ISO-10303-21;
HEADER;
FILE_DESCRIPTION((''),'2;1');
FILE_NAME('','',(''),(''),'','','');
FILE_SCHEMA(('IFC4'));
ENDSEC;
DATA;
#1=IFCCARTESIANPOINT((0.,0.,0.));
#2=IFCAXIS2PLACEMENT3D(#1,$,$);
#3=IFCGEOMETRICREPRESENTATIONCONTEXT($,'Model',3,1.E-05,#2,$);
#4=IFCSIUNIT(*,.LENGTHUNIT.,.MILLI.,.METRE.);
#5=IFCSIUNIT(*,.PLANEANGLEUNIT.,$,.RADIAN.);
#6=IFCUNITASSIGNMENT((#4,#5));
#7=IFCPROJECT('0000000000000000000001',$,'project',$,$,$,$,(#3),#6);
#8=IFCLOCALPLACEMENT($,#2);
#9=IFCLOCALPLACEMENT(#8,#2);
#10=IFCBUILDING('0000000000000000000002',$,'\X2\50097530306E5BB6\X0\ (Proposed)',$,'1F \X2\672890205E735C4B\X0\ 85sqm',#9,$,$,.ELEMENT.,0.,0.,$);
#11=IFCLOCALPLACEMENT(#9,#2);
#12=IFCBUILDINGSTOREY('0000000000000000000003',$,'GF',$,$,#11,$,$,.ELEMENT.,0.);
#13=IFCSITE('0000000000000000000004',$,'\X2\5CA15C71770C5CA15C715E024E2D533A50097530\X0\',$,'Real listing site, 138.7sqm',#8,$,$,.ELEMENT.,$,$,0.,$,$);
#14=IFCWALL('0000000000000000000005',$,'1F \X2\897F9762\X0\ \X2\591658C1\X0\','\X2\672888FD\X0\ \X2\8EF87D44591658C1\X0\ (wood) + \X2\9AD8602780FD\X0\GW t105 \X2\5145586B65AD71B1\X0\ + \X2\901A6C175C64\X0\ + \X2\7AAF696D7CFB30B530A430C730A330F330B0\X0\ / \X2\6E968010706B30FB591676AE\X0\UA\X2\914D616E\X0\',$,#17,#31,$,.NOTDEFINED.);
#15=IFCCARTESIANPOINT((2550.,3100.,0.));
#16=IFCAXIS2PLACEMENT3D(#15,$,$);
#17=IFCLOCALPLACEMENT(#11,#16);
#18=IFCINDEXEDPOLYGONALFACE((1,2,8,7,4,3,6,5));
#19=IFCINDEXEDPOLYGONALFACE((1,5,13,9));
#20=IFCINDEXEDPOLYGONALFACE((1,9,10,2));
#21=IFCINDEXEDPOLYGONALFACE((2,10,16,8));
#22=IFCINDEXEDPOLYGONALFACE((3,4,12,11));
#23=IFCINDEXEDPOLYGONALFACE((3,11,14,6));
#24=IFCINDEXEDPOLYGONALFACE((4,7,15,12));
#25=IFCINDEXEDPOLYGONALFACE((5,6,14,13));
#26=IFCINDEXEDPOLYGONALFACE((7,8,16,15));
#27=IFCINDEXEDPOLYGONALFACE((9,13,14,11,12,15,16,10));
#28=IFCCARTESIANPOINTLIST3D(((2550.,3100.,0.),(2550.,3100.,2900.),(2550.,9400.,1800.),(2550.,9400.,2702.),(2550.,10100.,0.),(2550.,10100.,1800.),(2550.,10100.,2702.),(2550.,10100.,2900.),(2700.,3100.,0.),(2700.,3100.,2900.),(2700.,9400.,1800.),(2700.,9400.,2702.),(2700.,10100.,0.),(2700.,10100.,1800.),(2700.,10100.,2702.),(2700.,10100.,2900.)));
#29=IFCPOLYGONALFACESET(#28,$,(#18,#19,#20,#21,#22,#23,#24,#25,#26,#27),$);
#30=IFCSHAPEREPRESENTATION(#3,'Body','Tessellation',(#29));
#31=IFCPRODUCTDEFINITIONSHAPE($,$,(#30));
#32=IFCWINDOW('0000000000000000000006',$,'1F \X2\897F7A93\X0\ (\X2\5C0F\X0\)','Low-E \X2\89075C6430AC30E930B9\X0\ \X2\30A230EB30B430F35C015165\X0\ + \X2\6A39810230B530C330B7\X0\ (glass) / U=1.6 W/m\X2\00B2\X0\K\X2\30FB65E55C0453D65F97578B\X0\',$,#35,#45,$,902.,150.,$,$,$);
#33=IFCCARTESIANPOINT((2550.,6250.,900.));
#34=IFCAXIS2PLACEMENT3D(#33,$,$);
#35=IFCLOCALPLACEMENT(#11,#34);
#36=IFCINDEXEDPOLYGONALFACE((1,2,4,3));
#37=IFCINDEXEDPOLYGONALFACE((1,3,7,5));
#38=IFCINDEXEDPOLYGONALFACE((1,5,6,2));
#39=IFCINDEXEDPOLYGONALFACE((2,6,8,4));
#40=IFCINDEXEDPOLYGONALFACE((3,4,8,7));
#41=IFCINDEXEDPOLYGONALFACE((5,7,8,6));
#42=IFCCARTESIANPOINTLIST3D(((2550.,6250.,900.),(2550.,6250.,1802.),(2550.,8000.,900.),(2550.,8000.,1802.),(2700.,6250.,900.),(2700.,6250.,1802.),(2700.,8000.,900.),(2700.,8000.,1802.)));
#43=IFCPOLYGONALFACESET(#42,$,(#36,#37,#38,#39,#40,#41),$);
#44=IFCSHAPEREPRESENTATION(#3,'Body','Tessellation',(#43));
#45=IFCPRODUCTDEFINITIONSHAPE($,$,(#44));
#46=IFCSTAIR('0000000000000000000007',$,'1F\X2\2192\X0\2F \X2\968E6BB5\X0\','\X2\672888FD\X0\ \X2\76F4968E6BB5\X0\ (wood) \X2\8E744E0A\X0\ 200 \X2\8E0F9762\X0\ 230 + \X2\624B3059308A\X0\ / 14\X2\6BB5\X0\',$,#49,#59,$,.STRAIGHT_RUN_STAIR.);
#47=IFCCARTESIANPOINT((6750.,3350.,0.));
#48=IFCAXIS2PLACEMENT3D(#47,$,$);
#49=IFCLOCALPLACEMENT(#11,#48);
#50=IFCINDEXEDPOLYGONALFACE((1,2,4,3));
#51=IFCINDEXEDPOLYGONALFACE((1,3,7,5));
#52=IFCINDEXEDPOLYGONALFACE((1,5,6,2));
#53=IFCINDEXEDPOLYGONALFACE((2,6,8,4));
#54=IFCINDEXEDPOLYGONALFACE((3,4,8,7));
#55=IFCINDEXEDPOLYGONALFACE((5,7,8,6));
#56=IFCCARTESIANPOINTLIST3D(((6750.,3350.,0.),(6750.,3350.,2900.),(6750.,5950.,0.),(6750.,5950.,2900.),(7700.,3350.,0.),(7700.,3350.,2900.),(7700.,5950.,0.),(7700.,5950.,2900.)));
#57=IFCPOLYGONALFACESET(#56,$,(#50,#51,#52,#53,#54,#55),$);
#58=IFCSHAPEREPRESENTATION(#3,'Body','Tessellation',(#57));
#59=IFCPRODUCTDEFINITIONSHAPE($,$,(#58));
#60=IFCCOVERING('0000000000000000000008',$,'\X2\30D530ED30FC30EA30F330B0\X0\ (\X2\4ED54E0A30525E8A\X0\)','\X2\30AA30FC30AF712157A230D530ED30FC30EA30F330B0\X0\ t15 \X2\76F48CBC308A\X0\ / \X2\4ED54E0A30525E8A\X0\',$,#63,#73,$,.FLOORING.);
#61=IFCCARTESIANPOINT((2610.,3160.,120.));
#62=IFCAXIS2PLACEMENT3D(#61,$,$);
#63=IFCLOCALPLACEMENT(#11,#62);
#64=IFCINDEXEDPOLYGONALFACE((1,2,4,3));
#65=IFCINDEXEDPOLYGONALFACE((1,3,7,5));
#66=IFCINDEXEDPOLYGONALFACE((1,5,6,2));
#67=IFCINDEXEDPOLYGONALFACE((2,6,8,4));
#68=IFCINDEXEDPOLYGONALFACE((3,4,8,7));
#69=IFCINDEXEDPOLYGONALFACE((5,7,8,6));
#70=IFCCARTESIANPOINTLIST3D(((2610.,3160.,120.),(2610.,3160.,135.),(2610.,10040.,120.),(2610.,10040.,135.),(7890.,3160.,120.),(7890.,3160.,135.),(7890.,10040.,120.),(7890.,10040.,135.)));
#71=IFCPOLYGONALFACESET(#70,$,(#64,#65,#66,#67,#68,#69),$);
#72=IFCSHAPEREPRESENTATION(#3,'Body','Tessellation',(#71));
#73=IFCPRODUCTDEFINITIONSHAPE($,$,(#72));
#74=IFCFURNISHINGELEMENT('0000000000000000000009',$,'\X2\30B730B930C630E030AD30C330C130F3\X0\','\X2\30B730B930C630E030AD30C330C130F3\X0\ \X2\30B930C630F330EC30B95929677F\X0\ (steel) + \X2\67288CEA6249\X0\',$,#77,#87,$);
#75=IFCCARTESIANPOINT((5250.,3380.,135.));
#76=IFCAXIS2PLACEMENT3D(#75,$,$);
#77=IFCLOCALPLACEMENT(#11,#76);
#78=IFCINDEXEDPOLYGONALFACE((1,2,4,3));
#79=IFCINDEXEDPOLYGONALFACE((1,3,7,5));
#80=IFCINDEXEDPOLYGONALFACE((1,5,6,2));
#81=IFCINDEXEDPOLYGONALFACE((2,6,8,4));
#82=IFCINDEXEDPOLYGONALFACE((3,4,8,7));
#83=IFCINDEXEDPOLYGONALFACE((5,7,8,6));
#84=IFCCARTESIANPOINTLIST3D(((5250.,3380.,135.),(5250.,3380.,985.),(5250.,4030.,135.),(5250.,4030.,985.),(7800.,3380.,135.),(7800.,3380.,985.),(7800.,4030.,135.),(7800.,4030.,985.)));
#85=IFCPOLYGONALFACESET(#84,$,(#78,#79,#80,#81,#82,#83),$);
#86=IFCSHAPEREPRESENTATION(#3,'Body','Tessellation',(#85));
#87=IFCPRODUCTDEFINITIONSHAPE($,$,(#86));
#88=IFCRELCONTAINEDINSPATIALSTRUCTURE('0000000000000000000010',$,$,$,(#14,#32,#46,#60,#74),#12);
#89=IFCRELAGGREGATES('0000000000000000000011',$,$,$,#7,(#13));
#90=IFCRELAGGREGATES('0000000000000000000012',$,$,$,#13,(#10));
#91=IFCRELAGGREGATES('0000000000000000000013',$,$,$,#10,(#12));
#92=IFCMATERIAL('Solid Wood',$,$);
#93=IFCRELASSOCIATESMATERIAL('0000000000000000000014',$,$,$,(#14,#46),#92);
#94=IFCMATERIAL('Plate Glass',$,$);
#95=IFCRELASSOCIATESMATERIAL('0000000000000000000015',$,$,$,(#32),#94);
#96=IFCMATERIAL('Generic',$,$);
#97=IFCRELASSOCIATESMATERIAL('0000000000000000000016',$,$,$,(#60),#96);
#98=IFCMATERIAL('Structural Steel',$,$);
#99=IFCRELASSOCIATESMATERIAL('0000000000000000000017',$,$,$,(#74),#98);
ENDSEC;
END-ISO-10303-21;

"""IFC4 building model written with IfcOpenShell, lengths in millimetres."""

from ifc_helpers import new_model, si_unit, frame, frame_2d, origin, place, context, project, spatial, rectangle, extrude, material, element, fill, save


model = new_model("IFC4")

# Units and contexts
model_context = context("Model", 3, precision=1e-05, world=origin())
ifc_project = project(units=[si_unit("LENGTHUNIT", "METRE", prefix="MILLI"), si_unit("PLANEANGLEUNIT", "RADIAN")], contexts=[model_context])

# Site, building, storey
site_placement = place(None, origin())
site = spatial("IfcSite", under=ifc_project, at=site_placement, Name="岡山県岡山市中区倉田", ObjectType="Real listing site, 138.7sqm", CompositionType="ELEMENT", RefElevation=0.0)
building_placement = place(site_placement, origin())
building = spatial("IfcBuilding", under=site, at=building_placement, Name="倉田の家 (Proposed)", ObjectType="1F 木造平屋 85sqm", CompositionType="ELEMENT", ElevationOfRefHeight=0.0, ElevationOfTerrain=0.0)
storey_placement = place(building_placement, origin())
storey = spatial("IfcBuildingStorey", under=building, at=storey_placement, Name="GF", CompositionType="ELEMENT", Elevation=0.0)

# Shared definitions
ifc_material_1 = material(Name="Solid Wood")
ifc_material_2 = material(Name="Generic")

# Shared definitions
ifc_material_3 = material(Name="Plate Glass")

# Wall, opening, window
wall_1_placement = place(storey_placement, frame((2550.0, 3100.0, 0.0)))
wall_1 = element("IfcWall", 1, at=wall_1_placement, inside=storey, material=ifc_material_1, Name="1F 西面 外壁", Description="木製 軸組外壁 (wood) + 高性能GW t105 充填断熱 + 通気層 + 窯業系サイディング / 準耐火・外皮UA配慮", PredefinedType="NOTDEFINED", context=model_context, shape_type="SweptSolid", body=[
    extrude(rectangle(XDim=150.0, YDim=7000.0, at=frame_2d((75.0, 3500.0))), frame((2550.0, 3100.0, 0.0)), (0.0, 0.0, 1.0), 2900.0),
])
opening_1_placement = place(storey_placement, frame((2550.0, 6250.0, 900.0)))
opening_1 = element("IfcOpeningElement", 2, at=opening_1_placement, cuts=wall_1, PredefinedType="NOTDEFINED", context=model_context, shape_type="SweptSolid", body=[
    extrude(rectangle(XDim=150.0, YDim=1750.0, at=frame_2d((75.0, 875.0))), frame((2550.0, 6250.0, 900.0)), (0.0, 0.0, 1.0), 902.0),
])
window_1_placement = place(storey_placement, frame((2550.0, 6250.0, 900.0)))
window_1 = element("IfcWindow", 3, at=window_1_placement, inside=storey, material=ifc_material_3, Name="1F 西窓 (小)", Description="Low-E 複層ガラス アルゴン封入 + 樹脂サッシ (glass) / U=1.6 W/m²K・日射取得型", OverallHeight=902.0, OverallWidth=150.0, context=model_context, shape_type="SweptSolid", body=[
    extrude(rectangle(XDim=150.0, YDim=1750.0, at=frame_2d((75.0, 875.0))), frame((2550.0, 6250.0, 900.0)), (0.0, 0.0, 1.0), 902.0),
])
fill(opening_1, window_1)

# Stair
stair_placement = place(storey_placement, frame((6750.0, 3350.0, 0.0)))
element("IfcStair", 4, at=stair_placement, inside=storey, material=ifc_material_1, Name="1F→2F 階段", Description="木製 直階段 (wood) 蹴上 200 踏面 230 + 手すり / 14段", PredefinedType="STRAIGHT_RUN_STAIR", context=model_context, shape_type="SweptSolid", body=[
    extrude(rectangle(XDim=950.0, YDim=2600.0, at=frame_2d((475.0, 1300.0))), frame((6750.0, 3350.0, 0.0)), (0.0, 0.0, 1.0), 2900.0),
])

# Covering
covering_placement = place(storey_placement, frame((2610.0, 3160.0, 120.0)))
element("IfcCovering", 5, at=covering_placement, inside=storey, material=ifc_material_2, Name="フローリング (仕上げ床)", Description="オーク無垢フローリング t15 直貼り / 仕上げ床", PredefinedType="FLOORING", context=model_context, shape_type="SweptSolid", body=[
    extrude(rectangle(XDim=5280.0, YDim=6880.0, at=frame_2d((2640.0, 3440.0))), frame((2610.0, 3160.0, 120.0)), (0.0, 0.0, 1.0), 15.0),
])

# Furnishing element
ifc_material_4 = material(Name="Structural Steel")
furnishing_placement = place(storey_placement, frame((5250.0, 3380.0, 135.0)))
element("IfcFurnishingElement", 6, at=furnishing_placement, inside=storey, material=ifc_material_4, Name="システムキッチン", Description="システムキッチン ステンレス天板 (steel) + 木質扉", context=model_context, shape_type="SweptSolid", body=[
    extrude(rectangle(XDim=2550.0, YDim=650.0, at=frame_2d((1275.0, 325.0))), frame((5250.0, 3380.0, 135.0)), (0.0, 0.0, 1.0), 850.0),
])

save(model, "model.ifc")
